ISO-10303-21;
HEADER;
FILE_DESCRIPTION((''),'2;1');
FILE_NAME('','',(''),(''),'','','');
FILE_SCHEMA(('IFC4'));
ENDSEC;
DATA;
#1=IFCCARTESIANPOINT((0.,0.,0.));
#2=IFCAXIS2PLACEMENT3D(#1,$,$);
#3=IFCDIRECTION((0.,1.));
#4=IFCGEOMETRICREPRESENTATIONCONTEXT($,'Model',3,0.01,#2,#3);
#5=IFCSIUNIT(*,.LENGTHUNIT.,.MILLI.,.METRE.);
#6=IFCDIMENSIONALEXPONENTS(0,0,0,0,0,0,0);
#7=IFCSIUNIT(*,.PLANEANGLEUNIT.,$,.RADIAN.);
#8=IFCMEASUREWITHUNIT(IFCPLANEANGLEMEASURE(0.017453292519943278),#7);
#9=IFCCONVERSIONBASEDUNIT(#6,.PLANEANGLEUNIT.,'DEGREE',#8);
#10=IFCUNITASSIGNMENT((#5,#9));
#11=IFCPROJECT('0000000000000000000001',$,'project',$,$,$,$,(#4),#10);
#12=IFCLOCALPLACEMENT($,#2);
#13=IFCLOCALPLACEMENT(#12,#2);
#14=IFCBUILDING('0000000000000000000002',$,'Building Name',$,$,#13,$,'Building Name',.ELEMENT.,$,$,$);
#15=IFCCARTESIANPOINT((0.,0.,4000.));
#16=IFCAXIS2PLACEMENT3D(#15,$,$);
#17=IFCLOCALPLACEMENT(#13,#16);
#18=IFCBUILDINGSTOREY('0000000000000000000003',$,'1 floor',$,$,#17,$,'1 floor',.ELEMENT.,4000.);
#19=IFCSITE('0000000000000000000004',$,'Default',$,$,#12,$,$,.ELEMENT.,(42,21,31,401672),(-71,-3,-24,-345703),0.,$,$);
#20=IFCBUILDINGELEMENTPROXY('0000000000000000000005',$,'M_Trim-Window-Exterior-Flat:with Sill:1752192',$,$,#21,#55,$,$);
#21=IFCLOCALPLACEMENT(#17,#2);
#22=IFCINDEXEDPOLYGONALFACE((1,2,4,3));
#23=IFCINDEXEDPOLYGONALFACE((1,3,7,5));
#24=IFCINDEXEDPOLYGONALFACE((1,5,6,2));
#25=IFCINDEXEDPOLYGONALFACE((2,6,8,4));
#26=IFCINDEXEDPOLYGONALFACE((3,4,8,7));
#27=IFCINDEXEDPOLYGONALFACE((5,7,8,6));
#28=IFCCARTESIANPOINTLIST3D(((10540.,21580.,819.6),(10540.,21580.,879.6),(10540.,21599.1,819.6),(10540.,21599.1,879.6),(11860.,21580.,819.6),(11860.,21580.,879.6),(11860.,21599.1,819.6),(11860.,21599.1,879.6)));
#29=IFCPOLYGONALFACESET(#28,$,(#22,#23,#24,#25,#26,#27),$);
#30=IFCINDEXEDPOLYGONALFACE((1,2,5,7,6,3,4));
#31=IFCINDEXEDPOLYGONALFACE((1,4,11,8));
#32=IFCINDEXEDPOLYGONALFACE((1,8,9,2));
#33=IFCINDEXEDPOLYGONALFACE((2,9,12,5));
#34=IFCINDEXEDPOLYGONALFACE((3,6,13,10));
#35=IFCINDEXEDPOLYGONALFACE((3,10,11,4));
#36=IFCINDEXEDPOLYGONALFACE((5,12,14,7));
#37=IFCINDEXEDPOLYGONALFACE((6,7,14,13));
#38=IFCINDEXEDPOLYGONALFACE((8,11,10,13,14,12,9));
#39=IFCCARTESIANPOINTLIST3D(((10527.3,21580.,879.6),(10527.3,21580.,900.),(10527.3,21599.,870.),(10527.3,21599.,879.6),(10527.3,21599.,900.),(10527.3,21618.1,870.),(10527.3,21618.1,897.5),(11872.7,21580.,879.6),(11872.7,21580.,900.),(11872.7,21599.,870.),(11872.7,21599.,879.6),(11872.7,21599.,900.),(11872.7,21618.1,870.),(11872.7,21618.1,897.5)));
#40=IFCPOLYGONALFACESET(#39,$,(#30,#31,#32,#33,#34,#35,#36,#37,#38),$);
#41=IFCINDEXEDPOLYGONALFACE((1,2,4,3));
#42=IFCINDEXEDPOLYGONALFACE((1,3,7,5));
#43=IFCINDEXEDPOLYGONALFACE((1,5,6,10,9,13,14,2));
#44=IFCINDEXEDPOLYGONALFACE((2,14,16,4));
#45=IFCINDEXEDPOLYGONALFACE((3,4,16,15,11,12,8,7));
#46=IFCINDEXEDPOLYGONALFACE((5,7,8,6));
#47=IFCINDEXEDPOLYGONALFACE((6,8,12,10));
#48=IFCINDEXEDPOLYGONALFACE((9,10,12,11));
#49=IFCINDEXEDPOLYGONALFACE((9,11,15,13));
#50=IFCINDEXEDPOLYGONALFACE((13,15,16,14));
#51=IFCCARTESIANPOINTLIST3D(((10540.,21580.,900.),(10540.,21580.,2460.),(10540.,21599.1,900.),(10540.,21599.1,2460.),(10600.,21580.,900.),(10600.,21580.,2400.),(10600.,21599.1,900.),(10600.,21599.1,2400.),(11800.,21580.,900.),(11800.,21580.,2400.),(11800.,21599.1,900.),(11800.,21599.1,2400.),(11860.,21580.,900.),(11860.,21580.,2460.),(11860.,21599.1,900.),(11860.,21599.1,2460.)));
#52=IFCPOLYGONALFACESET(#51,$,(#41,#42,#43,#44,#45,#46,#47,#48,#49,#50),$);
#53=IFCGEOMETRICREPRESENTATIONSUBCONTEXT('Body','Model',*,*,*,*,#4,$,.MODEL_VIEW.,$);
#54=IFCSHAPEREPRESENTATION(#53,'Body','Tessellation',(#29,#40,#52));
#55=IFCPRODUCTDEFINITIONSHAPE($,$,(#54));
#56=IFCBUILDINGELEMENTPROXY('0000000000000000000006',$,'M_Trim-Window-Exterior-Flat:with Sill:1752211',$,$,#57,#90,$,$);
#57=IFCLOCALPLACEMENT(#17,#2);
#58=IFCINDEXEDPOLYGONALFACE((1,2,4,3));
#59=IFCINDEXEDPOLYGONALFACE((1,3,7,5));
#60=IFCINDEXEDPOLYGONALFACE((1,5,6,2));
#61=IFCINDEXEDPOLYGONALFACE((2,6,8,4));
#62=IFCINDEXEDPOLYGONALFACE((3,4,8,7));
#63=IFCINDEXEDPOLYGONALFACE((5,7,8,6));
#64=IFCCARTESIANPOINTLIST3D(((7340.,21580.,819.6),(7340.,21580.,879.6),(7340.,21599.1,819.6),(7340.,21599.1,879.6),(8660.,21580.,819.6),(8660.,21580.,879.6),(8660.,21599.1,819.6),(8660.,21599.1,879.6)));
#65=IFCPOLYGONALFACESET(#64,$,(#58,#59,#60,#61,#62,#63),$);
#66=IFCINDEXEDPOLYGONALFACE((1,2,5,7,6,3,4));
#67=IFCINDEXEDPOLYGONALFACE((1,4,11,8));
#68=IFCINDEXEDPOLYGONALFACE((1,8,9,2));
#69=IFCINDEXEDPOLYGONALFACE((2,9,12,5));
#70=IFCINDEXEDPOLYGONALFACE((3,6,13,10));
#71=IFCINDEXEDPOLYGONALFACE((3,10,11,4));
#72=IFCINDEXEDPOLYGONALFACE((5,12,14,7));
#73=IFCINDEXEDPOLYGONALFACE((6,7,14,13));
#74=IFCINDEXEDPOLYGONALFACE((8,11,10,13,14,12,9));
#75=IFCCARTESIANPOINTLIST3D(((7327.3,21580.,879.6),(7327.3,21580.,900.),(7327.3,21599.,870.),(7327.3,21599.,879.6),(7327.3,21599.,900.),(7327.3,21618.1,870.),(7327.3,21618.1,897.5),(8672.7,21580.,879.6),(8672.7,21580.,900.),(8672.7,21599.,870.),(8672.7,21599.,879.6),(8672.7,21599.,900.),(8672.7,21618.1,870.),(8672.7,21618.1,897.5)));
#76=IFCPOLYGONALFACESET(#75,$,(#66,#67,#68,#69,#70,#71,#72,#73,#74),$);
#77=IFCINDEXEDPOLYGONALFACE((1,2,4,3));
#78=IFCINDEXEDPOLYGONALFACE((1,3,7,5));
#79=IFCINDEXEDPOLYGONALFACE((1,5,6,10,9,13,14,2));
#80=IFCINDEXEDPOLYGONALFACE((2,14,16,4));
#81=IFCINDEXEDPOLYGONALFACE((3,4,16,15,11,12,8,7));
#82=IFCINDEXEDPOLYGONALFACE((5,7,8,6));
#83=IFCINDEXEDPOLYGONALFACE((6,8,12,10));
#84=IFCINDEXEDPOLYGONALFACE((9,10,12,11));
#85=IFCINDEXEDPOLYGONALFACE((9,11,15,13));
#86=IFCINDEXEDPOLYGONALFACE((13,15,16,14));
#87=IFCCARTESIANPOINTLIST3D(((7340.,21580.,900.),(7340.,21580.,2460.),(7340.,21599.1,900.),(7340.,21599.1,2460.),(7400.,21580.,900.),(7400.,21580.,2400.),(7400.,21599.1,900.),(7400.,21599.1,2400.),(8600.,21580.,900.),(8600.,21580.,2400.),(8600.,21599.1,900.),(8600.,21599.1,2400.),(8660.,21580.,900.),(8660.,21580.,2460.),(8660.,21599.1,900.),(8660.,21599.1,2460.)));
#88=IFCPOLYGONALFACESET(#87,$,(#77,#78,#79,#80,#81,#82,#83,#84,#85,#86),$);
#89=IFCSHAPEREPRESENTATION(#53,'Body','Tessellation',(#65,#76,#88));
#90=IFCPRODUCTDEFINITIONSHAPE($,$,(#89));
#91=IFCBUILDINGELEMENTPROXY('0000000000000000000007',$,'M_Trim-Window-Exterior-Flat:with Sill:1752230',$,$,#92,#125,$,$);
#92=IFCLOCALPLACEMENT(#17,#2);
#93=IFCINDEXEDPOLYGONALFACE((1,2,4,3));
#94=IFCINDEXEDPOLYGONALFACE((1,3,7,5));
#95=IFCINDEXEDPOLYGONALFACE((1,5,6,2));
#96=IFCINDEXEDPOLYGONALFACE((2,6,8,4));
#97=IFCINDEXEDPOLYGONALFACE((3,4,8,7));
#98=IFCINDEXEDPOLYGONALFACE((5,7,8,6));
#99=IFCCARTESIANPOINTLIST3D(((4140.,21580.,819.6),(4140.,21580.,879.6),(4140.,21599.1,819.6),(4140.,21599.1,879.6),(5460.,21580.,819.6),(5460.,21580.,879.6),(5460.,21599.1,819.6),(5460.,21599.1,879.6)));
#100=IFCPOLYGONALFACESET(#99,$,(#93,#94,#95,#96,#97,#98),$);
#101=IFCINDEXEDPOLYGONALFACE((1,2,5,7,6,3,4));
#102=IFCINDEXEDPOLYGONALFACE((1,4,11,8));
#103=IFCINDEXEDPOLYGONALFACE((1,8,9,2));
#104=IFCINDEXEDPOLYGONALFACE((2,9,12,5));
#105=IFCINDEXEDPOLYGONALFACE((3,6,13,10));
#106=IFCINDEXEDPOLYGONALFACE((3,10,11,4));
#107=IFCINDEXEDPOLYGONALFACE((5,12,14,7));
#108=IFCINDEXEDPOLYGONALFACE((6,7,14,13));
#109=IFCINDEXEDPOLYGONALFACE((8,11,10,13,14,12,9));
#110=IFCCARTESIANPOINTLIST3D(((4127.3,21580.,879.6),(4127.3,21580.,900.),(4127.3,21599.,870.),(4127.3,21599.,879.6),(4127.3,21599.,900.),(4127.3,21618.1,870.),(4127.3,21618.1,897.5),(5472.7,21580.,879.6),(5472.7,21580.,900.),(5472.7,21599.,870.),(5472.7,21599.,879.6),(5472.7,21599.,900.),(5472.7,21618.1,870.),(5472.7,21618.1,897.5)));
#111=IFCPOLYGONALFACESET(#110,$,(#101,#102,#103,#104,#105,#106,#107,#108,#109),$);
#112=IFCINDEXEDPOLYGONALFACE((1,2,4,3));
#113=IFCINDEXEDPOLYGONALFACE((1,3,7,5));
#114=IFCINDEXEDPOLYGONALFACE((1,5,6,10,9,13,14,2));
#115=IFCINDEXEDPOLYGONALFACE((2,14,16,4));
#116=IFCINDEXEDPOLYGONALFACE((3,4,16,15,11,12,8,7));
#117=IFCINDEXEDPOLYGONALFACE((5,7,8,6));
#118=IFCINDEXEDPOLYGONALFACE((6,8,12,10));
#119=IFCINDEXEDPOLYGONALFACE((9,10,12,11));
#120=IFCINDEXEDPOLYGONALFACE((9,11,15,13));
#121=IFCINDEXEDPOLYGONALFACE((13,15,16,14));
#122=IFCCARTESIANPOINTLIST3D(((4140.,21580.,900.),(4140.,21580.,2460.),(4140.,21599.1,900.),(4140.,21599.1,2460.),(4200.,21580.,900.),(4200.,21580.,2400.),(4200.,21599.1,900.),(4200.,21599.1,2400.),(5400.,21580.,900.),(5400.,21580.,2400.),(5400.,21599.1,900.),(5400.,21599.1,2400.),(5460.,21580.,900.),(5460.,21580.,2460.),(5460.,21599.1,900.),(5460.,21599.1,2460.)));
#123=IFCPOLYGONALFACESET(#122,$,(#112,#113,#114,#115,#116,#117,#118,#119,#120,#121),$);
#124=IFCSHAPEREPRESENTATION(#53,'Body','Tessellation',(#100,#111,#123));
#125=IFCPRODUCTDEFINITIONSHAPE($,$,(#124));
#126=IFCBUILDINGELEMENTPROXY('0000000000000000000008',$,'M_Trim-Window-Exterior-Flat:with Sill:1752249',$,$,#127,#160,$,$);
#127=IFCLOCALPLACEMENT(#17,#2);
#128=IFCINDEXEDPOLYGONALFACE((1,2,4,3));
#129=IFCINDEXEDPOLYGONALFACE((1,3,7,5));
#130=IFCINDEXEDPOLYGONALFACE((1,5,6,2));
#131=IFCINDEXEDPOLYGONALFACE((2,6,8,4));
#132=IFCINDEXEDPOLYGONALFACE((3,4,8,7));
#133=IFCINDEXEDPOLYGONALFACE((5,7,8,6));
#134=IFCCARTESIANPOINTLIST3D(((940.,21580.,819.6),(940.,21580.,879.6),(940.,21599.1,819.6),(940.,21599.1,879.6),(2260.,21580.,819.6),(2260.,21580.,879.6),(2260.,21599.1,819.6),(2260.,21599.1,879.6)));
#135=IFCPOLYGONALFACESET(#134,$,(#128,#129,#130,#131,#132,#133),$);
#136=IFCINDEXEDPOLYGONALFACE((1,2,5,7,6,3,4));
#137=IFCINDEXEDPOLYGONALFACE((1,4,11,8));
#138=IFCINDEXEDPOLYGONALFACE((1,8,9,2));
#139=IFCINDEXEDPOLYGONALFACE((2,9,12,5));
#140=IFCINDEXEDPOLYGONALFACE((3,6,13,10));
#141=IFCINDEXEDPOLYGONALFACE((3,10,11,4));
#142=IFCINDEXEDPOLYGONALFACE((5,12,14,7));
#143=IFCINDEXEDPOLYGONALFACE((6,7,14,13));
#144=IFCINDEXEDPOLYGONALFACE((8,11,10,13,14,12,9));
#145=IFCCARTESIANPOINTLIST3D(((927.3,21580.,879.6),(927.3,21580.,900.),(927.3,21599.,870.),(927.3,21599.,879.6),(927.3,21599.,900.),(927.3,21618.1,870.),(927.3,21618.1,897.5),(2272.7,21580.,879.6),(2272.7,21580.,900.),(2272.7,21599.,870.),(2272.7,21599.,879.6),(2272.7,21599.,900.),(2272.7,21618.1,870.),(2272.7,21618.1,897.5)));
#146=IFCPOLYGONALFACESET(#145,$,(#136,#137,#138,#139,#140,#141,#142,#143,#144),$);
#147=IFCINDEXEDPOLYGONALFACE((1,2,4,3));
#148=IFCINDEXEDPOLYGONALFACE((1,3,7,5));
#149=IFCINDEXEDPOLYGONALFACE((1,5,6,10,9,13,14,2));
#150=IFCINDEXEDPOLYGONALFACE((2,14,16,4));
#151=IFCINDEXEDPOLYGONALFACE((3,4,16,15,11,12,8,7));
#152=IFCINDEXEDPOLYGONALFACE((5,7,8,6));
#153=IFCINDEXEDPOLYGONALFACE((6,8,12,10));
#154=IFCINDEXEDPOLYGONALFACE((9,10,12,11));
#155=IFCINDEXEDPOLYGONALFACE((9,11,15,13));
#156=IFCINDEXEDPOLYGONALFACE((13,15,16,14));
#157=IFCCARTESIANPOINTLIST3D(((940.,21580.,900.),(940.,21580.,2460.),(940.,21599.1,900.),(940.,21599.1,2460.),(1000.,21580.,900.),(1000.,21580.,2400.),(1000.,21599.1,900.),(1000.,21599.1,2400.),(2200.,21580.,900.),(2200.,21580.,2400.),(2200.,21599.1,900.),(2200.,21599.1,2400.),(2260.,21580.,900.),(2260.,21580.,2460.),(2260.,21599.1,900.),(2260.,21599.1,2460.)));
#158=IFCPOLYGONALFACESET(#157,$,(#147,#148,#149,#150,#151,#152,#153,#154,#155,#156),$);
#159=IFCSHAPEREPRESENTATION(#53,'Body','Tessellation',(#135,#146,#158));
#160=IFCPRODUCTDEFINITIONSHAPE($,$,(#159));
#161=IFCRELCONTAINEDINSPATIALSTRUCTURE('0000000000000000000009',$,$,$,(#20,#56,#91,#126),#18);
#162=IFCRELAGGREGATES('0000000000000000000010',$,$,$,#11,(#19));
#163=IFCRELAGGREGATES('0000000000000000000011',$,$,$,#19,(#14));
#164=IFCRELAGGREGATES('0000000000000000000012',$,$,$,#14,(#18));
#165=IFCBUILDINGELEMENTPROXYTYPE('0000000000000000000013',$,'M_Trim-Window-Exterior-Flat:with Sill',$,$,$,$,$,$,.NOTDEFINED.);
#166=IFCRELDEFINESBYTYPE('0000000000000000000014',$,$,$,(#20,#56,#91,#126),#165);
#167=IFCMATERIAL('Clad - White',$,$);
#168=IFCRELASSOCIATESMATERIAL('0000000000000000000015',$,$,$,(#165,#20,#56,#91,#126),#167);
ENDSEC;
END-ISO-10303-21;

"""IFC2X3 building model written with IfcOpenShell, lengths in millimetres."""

from ifc_helpers import new_model, entity, si_unit, converted_unit, direction, frame, frame_2d, origin, place, context, subcontext, project, spatial, polyline, rectangle, outline, extrude, source, transform, mapped, material, type_object, type_shapes, element, save


model = new_model("IFC2X3")

# Units and contexts
model_context = context("Model", 3, precision=0.01, world=origin(), true_north=direction((0.0, 1.0)))
body_context = subcontext(model_context, "Body", "Model", "MODEL_VIEW")
ifc_project = project(units=[si_unit("LENGTHUNIT", "METRE", prefix="MILLI"), converted_unit("PLANEANGLEUNIT", "DEGREE", entity("IfcPlaneAngleMeasure", 0.017453292519943278), si_unit("PLANEANGLEUNIT", "RADIAN"), dimensions=[0, 0, 0, 0, 0, 0, 0])], contexts=[model_context])

# Site, building, storey
site_placement = place(None, origin())
site = spatial("IfcSite", under=ifc_project, at=site_placement, Name="Default", CompositionType="ELEMENT", RefLatitude=(42, 21, 31, 401672), RefLongitude=(-71, -3, -24, -345703), RefElevation=0.0)
building_placement = place(site_placement, origin())
building = spatial("IfcBuilding", under=site, at=building_placement, Name="Building Name", LongName="Building Name", CompositionType="ELEMENT")
storey_placement = place(building_placement, frame((0.0, 0.0, 4000.0)))
storey = spatial("IfcBuildingStorey", under=building, at=storey_placement, Name="1 floor", LongName="1 floor", CompositionType="ELEMENT", Elevation=4000.0)

# Building element proxies
ifc_material_1 = material(Name="Clad - White")
building_element_proxy_type_1 = type_object("IfcBuildingElementProxyType", Name="M_Trim-Window-Exterior-Flat:with Sill", PredefinedType="NOTDEFINED", material=ifc_material_1)
shared_shape_1 = source(origin(), body_context, "Body", "SweptSolid", [
    extrude(rectangle(XDim=1320.0, YDim=60.0, at=frame_2d((0.0, 0.0), x_axis=(1.0, 0.0))), frame((0.0, -1550.4, 0.0), z_axis=(0.0, 0.0, 1.0), x_axis=(-1.0, 0.0, 0.0)), (0.0, 0.0, 1.0), 19.0),
    extrude(outline(polyline([(-19.0, -15.2), (0.0, -15.2), (0.0, -5.7), (19.0, -5.7), (19.0, 14.8), (0.0, 14.8), (-19.0, 12.3), (-19.0, -15.2)])), frame((-672.7, -1514.8, 19.0), z_axis=(1.0, 0.0, 0.0), x_axis=(0.0, 0.0, -1.0)), (0.0, 0.0, 1.0), 1345.4),
    extrude(outline(polyline([(-795.0, -660.0), (765.0, -660.0), (765.0, -600.0), (-735.0, -600.0), (-735.0, 600.0), (765.0, 600.0), (765.0, 660.0), (-795.0, 660.0), (-795.0, -660.0)])), frame((0.0, -735.0, 0.0), z_axis=(0.0, 0.0, 1.0), x_axis=(0.0, -1.0, 0.0)), (0.0, 0.0, 1.0), 19.0),
])
type_shapes(building_element_proxy_type_1, [shared_shape_1])
for number, where, z_axis, x_axis, name in (
    (1, (11200.0, 21580.0, 2400.0), (0.0, 1.0, 0.0), (-1.0, 0.0, 0.0), "M_Trim-Window-Exterior-Flat:with Sill:1752192"),
    (2, (8000.0, 21580.0, 2400.0), (0.0, 1.0, 0.0), (-1.0, 0.0, 0.0), "M_Trim-Window-Exterior-Flat:with Sill:1752211"),
    (3, (4800.0, 21580.0, 2400.0), (0.0, 1.0, 0.0), (-1.0, 0.0, 0.0), "M_Trim-Window-Exterior-Flat:with Sill:1752230"),
    (4, (1600.0, 21580.0, 2400.0), (0.0, 1.0, 0.0), (-1.0, 0.0, 0.0), "M_Trim-Window-Exterior-Flat:with Sill:1752249"),
):
    element("IfcBuildingElementProxy", number, at=place(storey_placement, frame(where, z_axis=z_axis, x_axis=x_axis)), inside=storey, type_object=building_element_proxy_type_1, material=ifc_material_1, Name=name, context=body_context, shape_type="MappedRepresentation", body=[
        mapped(shared_shape_1, transform((0.0, 0.0, 0.0), scale=1.0)),
    ])

save(model, "model.ifc")
